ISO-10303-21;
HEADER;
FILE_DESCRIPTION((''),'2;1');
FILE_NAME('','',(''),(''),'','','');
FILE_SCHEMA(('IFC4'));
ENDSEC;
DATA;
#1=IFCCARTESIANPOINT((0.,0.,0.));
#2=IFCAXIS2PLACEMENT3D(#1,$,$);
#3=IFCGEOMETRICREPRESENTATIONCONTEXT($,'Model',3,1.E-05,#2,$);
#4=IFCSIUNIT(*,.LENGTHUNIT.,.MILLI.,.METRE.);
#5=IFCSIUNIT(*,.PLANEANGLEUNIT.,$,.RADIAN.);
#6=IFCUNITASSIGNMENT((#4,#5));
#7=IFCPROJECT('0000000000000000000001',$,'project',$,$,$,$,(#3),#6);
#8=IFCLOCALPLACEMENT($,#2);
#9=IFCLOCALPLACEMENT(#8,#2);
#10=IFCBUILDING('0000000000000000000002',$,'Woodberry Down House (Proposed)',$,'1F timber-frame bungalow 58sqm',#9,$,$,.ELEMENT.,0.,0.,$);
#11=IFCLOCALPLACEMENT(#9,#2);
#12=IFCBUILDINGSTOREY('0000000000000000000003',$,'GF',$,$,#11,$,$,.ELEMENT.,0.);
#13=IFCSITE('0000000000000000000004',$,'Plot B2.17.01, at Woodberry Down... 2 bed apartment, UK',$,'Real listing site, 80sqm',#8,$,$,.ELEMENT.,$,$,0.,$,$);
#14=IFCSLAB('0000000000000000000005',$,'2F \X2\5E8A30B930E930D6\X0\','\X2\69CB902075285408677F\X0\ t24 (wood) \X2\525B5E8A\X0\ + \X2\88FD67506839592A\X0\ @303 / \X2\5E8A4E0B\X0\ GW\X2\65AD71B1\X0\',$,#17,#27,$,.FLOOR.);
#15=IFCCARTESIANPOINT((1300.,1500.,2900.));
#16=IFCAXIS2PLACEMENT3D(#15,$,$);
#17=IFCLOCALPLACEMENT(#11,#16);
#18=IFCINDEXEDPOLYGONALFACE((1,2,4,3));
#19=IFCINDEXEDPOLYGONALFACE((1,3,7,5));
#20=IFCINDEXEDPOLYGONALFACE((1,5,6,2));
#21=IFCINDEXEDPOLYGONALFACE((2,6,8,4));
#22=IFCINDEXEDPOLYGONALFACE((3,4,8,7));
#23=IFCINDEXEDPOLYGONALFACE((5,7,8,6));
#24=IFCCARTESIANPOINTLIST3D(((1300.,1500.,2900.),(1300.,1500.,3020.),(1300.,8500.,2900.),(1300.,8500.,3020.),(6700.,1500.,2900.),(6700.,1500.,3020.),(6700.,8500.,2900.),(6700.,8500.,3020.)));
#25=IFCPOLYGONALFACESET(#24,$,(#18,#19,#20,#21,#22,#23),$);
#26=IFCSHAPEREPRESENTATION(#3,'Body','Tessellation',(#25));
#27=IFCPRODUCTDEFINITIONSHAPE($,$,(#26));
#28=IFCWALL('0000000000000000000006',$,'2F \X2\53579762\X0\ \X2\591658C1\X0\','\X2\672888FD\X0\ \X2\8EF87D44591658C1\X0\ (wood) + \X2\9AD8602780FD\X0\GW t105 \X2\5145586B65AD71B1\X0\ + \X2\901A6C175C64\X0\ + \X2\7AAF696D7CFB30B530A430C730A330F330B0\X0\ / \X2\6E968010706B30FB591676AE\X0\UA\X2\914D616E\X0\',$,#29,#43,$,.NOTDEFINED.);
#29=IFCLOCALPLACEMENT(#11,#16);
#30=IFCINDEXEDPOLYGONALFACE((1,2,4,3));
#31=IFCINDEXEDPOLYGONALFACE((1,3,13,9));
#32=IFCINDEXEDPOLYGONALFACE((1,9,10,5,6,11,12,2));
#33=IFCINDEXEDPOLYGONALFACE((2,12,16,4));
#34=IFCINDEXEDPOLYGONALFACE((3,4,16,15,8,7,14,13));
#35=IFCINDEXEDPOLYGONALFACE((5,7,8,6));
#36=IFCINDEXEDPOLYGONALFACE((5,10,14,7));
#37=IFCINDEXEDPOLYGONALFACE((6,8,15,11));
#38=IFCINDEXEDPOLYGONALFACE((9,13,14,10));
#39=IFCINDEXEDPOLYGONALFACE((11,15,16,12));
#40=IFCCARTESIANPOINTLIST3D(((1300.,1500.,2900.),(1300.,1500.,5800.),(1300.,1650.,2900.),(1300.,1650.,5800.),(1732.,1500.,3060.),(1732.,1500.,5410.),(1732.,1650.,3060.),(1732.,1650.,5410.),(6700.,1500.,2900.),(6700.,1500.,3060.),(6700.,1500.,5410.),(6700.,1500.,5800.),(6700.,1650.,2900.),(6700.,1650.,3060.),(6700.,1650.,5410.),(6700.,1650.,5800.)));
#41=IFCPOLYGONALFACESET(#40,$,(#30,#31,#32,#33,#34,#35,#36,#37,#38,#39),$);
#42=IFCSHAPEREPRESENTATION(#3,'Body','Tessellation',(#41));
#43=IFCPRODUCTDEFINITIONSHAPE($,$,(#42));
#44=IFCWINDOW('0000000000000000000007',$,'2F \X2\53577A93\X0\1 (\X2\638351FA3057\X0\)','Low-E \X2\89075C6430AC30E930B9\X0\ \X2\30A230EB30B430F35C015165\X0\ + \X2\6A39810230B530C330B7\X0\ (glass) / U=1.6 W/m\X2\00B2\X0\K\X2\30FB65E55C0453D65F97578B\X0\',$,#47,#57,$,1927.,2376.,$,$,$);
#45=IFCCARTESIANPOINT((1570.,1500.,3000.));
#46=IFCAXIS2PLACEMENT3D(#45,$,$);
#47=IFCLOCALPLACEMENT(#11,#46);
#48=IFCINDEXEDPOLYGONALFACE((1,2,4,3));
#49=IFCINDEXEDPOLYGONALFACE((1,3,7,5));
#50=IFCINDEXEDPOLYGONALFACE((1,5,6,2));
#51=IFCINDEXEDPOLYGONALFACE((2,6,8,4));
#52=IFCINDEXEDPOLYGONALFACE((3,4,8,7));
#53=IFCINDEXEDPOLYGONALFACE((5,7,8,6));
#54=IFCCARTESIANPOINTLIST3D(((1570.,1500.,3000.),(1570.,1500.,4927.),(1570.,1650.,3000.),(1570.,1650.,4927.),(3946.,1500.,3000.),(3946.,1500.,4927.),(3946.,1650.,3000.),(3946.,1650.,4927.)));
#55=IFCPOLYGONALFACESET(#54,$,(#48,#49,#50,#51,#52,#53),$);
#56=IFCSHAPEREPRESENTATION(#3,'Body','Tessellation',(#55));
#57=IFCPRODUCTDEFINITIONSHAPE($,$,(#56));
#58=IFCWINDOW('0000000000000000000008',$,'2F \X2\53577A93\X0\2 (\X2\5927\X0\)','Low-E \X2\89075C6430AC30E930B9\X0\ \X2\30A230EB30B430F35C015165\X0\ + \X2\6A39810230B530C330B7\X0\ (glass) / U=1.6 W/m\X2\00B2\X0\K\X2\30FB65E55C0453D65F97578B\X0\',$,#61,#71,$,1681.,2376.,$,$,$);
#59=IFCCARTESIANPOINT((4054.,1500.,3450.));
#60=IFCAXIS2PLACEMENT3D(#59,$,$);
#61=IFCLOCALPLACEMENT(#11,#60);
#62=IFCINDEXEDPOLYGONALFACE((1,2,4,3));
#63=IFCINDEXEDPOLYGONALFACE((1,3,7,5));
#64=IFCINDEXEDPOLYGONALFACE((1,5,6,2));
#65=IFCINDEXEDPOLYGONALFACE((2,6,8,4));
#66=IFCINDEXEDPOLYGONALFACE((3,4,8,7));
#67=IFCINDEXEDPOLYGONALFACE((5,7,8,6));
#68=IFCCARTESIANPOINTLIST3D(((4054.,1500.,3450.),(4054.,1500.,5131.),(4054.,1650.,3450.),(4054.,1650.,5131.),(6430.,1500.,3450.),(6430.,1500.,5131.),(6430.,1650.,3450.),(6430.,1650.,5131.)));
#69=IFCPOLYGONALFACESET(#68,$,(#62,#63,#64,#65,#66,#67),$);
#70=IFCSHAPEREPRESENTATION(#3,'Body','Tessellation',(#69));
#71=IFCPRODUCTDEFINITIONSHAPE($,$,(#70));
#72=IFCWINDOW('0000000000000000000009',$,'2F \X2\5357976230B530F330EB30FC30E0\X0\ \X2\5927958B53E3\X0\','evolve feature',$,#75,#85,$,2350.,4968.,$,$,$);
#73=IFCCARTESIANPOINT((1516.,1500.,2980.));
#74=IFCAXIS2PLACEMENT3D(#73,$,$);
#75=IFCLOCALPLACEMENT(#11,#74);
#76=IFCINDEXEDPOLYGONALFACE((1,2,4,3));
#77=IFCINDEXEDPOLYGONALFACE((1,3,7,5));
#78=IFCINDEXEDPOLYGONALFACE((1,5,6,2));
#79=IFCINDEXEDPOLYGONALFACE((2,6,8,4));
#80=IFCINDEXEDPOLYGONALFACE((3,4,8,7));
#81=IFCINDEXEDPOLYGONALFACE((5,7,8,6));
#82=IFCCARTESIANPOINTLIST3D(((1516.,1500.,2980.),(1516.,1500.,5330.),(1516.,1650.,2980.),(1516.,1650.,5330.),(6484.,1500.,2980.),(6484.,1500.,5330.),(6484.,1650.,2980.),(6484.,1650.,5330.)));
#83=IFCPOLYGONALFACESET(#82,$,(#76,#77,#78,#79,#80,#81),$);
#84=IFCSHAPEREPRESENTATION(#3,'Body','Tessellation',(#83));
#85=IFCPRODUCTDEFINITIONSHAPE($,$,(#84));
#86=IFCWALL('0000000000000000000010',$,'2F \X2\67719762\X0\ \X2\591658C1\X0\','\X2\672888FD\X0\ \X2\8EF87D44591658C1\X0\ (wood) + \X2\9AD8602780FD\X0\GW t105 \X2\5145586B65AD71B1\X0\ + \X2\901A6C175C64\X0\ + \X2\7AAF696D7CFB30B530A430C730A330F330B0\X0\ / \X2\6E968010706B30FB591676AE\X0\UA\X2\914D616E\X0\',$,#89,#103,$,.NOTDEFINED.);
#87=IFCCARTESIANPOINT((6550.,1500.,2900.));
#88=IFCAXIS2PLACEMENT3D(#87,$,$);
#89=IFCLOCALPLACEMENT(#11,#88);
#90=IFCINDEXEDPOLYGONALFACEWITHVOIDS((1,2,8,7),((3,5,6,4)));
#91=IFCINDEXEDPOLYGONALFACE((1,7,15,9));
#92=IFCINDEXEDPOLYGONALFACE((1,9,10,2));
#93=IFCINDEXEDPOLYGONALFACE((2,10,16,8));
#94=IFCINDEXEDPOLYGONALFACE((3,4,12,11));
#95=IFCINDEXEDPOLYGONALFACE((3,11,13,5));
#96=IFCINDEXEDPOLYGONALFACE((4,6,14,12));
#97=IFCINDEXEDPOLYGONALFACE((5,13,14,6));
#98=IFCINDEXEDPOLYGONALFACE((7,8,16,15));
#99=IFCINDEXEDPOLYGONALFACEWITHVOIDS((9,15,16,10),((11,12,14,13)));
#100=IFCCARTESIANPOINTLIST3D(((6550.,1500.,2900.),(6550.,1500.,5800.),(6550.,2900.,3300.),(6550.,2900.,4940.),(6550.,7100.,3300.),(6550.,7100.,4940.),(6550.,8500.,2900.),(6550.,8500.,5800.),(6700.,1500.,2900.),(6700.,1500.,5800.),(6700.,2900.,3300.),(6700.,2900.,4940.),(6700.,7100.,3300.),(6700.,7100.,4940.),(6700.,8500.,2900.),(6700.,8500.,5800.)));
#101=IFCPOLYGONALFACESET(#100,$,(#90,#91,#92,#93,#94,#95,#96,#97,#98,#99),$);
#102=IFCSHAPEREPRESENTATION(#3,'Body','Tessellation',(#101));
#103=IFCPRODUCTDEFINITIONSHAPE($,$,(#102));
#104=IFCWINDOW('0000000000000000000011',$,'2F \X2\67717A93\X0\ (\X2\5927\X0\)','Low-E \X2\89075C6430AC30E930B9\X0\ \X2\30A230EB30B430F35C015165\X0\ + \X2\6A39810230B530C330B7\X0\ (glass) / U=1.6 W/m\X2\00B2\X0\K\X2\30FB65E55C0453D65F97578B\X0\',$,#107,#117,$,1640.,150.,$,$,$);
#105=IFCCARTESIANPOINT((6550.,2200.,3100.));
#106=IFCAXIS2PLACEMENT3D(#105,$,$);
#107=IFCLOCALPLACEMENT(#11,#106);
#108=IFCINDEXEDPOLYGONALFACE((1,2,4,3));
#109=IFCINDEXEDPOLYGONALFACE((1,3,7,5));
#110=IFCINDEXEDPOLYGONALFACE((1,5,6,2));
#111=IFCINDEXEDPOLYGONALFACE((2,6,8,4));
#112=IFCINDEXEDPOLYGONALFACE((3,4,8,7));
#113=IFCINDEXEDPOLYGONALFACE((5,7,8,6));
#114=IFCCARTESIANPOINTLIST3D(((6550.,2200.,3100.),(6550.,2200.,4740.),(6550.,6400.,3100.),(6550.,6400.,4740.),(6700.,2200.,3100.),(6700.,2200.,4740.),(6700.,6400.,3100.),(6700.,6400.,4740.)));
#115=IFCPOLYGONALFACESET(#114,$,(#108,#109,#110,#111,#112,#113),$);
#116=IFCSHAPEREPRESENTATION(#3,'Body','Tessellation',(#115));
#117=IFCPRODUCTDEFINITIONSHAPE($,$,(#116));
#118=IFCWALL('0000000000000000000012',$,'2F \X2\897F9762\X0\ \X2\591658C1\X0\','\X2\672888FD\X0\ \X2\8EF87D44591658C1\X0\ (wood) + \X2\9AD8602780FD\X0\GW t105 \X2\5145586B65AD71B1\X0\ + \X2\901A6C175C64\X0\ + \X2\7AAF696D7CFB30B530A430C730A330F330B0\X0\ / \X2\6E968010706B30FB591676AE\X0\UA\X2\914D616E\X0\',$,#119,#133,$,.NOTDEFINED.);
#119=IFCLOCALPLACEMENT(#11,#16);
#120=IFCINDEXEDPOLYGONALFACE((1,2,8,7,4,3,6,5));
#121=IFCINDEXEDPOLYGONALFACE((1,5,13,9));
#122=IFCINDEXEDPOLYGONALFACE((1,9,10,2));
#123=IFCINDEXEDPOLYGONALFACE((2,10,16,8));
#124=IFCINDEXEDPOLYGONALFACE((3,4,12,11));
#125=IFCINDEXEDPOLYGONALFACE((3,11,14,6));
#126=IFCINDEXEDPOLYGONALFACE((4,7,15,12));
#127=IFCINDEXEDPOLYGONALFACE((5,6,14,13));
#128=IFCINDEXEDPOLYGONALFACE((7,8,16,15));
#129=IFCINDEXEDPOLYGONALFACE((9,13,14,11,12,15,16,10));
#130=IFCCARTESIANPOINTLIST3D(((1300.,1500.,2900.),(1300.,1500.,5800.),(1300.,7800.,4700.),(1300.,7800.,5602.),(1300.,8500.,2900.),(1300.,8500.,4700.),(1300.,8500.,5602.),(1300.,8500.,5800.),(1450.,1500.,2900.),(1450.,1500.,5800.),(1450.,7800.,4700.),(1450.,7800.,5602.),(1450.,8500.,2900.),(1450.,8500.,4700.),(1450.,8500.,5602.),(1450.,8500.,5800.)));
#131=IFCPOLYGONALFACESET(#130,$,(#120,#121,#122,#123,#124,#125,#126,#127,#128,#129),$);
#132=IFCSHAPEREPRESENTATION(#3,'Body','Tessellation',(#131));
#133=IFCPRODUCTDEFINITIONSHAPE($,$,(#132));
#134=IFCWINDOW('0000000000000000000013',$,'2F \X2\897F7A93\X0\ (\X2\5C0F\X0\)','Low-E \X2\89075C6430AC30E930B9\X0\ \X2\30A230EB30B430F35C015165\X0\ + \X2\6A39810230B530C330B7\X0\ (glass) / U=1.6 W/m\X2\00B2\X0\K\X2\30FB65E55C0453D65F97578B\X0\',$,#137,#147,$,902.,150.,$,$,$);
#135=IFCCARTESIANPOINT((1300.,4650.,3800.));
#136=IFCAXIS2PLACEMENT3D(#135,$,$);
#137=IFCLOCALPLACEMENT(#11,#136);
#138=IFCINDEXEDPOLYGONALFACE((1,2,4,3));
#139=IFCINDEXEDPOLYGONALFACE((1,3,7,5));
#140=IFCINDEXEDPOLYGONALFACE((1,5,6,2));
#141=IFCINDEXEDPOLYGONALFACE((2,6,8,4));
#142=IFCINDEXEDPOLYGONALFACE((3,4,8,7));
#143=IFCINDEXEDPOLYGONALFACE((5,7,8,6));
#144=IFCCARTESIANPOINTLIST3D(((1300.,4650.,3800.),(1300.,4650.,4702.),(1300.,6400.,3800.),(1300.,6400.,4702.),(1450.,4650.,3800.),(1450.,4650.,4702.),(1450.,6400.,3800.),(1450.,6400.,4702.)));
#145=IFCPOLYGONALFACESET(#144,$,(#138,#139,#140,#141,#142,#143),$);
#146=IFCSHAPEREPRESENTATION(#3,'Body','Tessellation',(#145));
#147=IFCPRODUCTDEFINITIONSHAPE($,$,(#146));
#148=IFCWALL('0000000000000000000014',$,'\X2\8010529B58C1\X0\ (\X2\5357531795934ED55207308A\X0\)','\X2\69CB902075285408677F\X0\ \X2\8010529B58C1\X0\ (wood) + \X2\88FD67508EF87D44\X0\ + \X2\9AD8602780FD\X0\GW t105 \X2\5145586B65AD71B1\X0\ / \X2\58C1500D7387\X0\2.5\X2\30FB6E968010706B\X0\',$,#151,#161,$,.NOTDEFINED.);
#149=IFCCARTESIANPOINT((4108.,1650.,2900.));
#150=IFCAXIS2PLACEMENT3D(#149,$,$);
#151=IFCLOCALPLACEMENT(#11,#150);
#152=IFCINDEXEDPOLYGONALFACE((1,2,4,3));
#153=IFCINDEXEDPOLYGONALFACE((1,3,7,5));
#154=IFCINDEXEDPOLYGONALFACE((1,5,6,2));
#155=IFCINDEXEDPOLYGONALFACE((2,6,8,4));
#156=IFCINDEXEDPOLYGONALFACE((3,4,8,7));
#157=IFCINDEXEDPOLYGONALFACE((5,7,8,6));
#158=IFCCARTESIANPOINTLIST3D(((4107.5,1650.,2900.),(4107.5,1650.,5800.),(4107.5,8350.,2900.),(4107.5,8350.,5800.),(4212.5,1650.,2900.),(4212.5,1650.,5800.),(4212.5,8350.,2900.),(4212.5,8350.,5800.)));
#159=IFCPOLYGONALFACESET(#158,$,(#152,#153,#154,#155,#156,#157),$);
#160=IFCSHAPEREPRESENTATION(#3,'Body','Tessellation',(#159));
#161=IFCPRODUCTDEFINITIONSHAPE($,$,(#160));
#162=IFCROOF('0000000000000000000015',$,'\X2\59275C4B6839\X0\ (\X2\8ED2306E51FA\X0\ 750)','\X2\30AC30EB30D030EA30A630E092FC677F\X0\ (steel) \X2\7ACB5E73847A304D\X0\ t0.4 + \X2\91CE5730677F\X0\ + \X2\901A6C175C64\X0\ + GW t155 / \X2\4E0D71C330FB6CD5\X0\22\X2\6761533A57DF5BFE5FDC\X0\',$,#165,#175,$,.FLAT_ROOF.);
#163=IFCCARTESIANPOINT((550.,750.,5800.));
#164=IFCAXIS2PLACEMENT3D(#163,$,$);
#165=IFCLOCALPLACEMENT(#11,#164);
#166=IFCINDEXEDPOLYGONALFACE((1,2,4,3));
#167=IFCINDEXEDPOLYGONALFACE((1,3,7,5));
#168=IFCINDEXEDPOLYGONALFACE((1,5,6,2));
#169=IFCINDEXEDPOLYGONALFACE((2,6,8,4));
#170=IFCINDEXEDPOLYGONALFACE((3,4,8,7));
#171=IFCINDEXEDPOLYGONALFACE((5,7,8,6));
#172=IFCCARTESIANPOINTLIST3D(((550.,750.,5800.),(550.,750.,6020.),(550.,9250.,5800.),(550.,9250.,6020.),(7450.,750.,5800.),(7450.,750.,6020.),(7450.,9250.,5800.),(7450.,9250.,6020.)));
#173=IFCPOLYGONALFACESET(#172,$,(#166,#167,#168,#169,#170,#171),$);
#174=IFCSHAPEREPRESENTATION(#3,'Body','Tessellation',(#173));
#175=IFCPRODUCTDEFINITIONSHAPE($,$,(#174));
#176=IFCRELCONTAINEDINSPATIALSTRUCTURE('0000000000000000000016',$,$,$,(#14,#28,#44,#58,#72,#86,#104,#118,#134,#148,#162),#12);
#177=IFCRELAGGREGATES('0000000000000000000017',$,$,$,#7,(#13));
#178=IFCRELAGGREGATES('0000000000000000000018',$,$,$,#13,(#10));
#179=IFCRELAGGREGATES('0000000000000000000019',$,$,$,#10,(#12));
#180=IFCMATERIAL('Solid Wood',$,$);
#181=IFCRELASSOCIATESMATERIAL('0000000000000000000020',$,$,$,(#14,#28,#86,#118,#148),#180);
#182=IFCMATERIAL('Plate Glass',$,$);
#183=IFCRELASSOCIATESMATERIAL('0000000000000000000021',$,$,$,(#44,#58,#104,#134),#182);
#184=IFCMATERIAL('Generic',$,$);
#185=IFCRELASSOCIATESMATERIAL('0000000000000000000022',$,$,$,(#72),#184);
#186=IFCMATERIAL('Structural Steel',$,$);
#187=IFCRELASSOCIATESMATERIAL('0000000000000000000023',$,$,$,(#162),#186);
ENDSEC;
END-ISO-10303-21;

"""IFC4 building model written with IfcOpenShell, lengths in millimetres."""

from ifc_helpers import new_model, si_unit, frame, frame_2d, origin, place, context, project, spatial, rectangle, extrude, material, element, fill, save


model = new_model("IFC4")

# Units and contexts
model_context = context("Model", 3, precision=1e-05, world=origin())
ifc_project = project(units=[si_unit("LENGTHUNIT", "METRE", prefix="MILLI"), si_unit("PLANEANGLEUNIT", "RADIAN")], contexts=[model_context])

# Site, building, storey
site_placement = place(None, origin())
site = spatial("IfcSite", under=ifc_project, at=site_placement, Name="Plot B2.17.01, at Woodberry Down... 2 bed apartment, UK", ObjectType="Real listing site, 80sqm", CompositionType="ELEMENT", RefElevation=0.0)
building_placement = place(site_placement, origin())
building = spatial("IfcBuilding", under=site, at=building_placement, Name="Woodberry Down House (Proposed)", ObjectType="1F timber-frame bungalow 58sqm", CompositionType="ELEMENT", ElevationOfRefHeight=0.0, ElevationOfTerrain=0.0)
storey_placement = place(building_placement, origin())
storey = spatial("IfcBuildingStorey", under=building, at=storey_placement, Name="GF", CompositionType="ELEMENT", Elevation=0.0)

# Slab
ifc_material_1 = material(Name="Solid Wood")
slab_placement = place(storey_placement, frame((1300.0, 1500.0, 2900.0)))
element("IfcSlab", 1, at=slab_placement, inside=storey, material=ifc_material_1, Name="2F 床スラブ", Description="構造用合板 t24 (wood) 剛床 + 製材根太 @303 / 床下 GW断熱", PredefinedType="FLOOR", context=model_context, shape_type="SweptSolid", body=[
    extrude(rectangle(XDim=5400.0, YDim=7000.0, at=frame_2d((2700.0, 3500.0))), frame((1300.0, 1500.0, 2900.0)), (0.0, 0.0, 1.0), 120.0),
])

# Wall, openings, windows
wall_1_placement = place(storey_placement, frame((1300.0, 1500.0, 2900.0)))
wall_1 = element("IfcWall", 2, at=wall_1_placement, inside=storey, material=ifc_material_1, Name="2F 南面 外壁", Description="木製 軸組外壁 (wood) + 高性能GW t105 充填断熱 + 通気層 + 窯業系サイディング / 準耐火・外皮UA配慮", PredefinedType="NOTDEFINED", context=model_context, shape_type="SweptSolid", body=[
    extrude(rectangle(XDim=5400.0, YDim=150.0, at=frame_2d((2700.0, 75.0))), frame((1300.0, 1500.0, 2900.0)), (0.0, 0.0, 1.0), 2900.0),
])
opening_1_placement = place(storey_placement, frame((1570.0, 1500.0, 3000.0)))
opening_1 = element("IfcOpeningElement", 3, at=opening_1_placement, cuts=wall_1, PredefinedType="NOTDEFINED", context=model_context, shape_type="SweptSolid", body=[
    extrude(rectangle(XDim=2376.0, YDim=150.0, at=frame_2d((1188.0, 75.0))), frame((1570.0, 1500.0, 3000.0)), (0.0, 0.0, 1.0), 1927.0),
])
opening_2_placement = place(storey_placement, frame((4054.0, 1500.0, 3450.0)))
opening_2 = element("IfcOpeningElement", 4, at=opening_2_placement, cuts=wall_1, PredefinedType="NOTDEFINED", context=model_context, shape_type="SweptSolid", body=[
    extrude(rectangle(XDim=2376.0, YDim=150.0, at=frame_2d((1188.0, 75.0))), frame((4054.0, 1500.0, 3450.0)), (0.0, 0.0, 1.0), 1681.0),
])
opening_3_placement = place(storey_placement, frame((1516.0, 1500.0, 2980.0)))
opening_3 = element("IfcOpeningElement", 5, at=opening_3_placement, cuts=wall_1, PredefinedType="NOTDEFINED", context=model_context, shape_type="SweptSolid", body=[
    extrude(rectangle(XDim=4968.0, YDim=150.0, at=frame_2d((2484.0, 75.0))), frame((1516.0, 1500.0, 2980.0)), (0.0, 0.0, 1.0), 2350.0),
])
ifc_material_2 = material(Name="Plate Glass")
window_1_placement = place(storey_placement, frame((1570.0, 1500.0, 3000.0)))
window_1 = element("IfcWindow", 6, at=window_1_placement, inside=storey, material=ifc_material_2, Name="2F 南窓1 (掃出し)", Description="Low-E 複層ガラス アルゴン封入 + 樹脂サッシ (glass) / U=1.6 W/m²K・日射取得型", OverallHeight=1927.0, OverallWidth=2376.0, context=model_context, shape_type="SweptSolid", body=[
    extrude(rectangle(XDim=2376.0, YDim=150.0, at=frame_2d((1188.0, 75.0))), frame((1570.0, 1500.0, 3000.0)), (0.0, 0.0, 1.0), 1927.0),
])
fill(opening_1, window_1)
window_2_placement = place(storey_placement, frame((4054.0, 1500.0, 3450.0)))
window_2 = element("IfcWindow", 7, at=window_2_placement, inside=storey, material=ifc_material_2, Name="2F 南窓2 (大)", Description="Low-E 複層ガラス アルゴン封入 + 樹脂サッシ (glass) / U=1.6 W/m²K・日射取得型", OverallHeight=1681.0, OverallWidth=2376.0, context=model_context, shape_type="SweptSolid", body=[
    extrude(rectangle(XDim=2376.0, YDim=150.0, at=frame_2d((1188.0, 75.0))), frame((4054.0, 1500.0, 3450.0)), (0.0, 0.0, 1.0), 1681.0),
])
fill(opening_2, window_2)
ifc_material_3 = material(Name="Generic")
window_3_placement = place(storey_placement, frame((1516.0, 1500.0, 2980.0)))
window_3 = element("IfcWindow", 8, at=window_3_placement, inside=storey, material=ifc_material_3, Name="2F 南面サンルーム 大開口", Description="evolve feature", OverallHeight=2350.0, OverallWidth=4968.0, context=model_context, shape_type="SweptSolid", body=[
    extrude(rectangle(XDim=4968.0, YDim=150.0, at=frame_2d((2484.0, 75.0))), frame((1516.0, 1500.0, 2980.0)), (0.0, 0.0, 1.0), 2350.0),
])
fill(opening_3, window_3)

# Walls, openings, windows
wall_2_placement = place(storey_placement, frame((6550.0, 1500.0, 2900.0)))
wall_2 = element("IfcWall", 9, at=wall_2_placement, inside=storey, material=ifc_material_1, Name="2F 東面 外壁", Description="木製 軸組外壁 (wood) + 高性能GW t105 充填断熱 + 通気層 + 窯業系サイディング / 準耐火・外皮UA配慮", PredefinedType="NOTDEFINED", context=model_context, shape_type="SweptSolid", body=[
    extrude(rectangle(XDim=150.0, YDim=7000.0, at=frame_2d((75.0, 3500.0))), frame((6550.0, 1500.0, 2900.0)), (0.0, 0.0, 1.0), 2900.0),
])
opening_4_placement = place(storey_placement, frame((6550.0, 2200.0, 3100.0)))
opening_4 = element("IfcOpeningElement", 10, at=opening_4_placement, cuts=wall_2, PredefinedType="NOTDEFINED", context=model_context, shape_type="SweptSolid", body=[
    extrude(rectangle(XDim=150.0, YDim=4200.0, at=frame_2d((75.0, 2100.0))), frame((6550.0, 2200.0, 3100.0)), (0.0, 0.0, 1.0), 1640.0),
])
window_4_placement = place(storey_placement, frame((6550.0, 2200.0, 3100.0)))
window_4 = element("IfcWindow", 11, at=window_4_placement, inside=storey, material=ifc_material_2, Name="2F 東窓 (大)", Description="Low-E 複層ガラス アルゴン封入 + 樹脂サッシ (glass) / U=1.6 W/m²K・日射取得型", OverallHeight=1640.0, OverallWidth=150.0, context=model_context, shape_type="SweptSolid", body=[
    extrude(rectangle(XDim=150.0, YDim=4200.0, at=frame_2d((75.0, 2100.0))), frame((6550.0, 2200.0, 3100.0)), (0.0, 0.0, 1.0), 1640.0),
])
fill(opening_4, window_4)
wall_3_placement = place(storey_placement, frame((1300.0, 1500.0, 2900.0)))
wall_3 = element("IfcWall", 12, at=wall_3_placement, inside=storey, material=ifc_material_1, Name="2F 西面 外壁", Description="木製 軸組外壁 (wood) + 高性能GW t105 充填断熱 + 通気層 + 窯業系サイディング / 準耐火・外皮UA配慮", PredefinedType="NOTDEFINED", context=model_context, shape_type="SweptSolid", body=[
    extrude(rectangle(XDim=150.0, YDim=7000.0, at=frame_2d((75.0, 3500.0))), frame((1300.0, 1500.0, 2900.0)), (0.0, 0.0, 1.0), 2900.0),
])
opening_5_placement = place(storey_placement, frame((1300.0, 4650.0, 3800.0)))
opening_5 = element("IfcOpeningElement", 13, at=opening_5_placement, cuts=wall_3, PredefinedType="NOTDEFINED", context=model_context, shape_type="SweptSolid", body=[
    extrude(rectangle(XDim=150.0, YDim=1750.0, at=frame_2d((75.0, 875.0))), frame((1300.0, 4650.0, 3800.0)), (0.0, 0.0, 1.0), 902.0),
])
window_5_placement = place(storey_placement, frame((1300.0, 4650.0, 3800.0)))
window_5 = element("IfcWindow", 14, at=window_5_placement, inside=storey, material=ifc_material_2, Name="2F 西窓 (小)", Description="Low-E 複層ガラス アルゴン封入 + 樹脂サッシ (glass) / U=1.6 W/m²K・日射取得型", OverallHeight=902.0, OverallWidth=150.0, context=model_context, shape_type="SweptSolid", body=[
    extrude(rectangle(XDim=150.0, YDim=1750.0, at=frame_2d((75.0, 875.0))), frame((1300.0, 4650.0, 3800.0)), (0.0, 0.0, 1.0), 902.0),
])
fill(opening_5, window_5)

# Wall
wall_4_placement = place(storey_placement, frame((4108.0, 1650.0, 2900.0)))
element("IfcWall", 15, at=wall_4_placement, inside=storey, material=ifc_material_1, Name="耐力壁 (南北間仕切り)", Description="構造用合板 耐力壁 (wood) + 製材軸組 + 高性能GW t105 充填断熱 / 壁倍率2.5・準耐火", PredefinedType="NOTDEFINED", context=model_context, shape_type="SweptSolid", body=[
    extrude(rectangle(XDim=105.0, YDim=6700.0, at=frame_2d((52.0, 3350.0))), frame((4108.0, 1650.0, 2900.0)), (0.0, 0.0, 1.0), 2900.0),
])

# Roof
ifc_material_4 = material(Name="Structural Steel")
roof_placement = place(storey_placement, frame((550.0, 750.0, 5800.0)))
element("IfcRoof", 16, at=roof_placement, inside=storey, material=ifc_material_4, Name="大屋根 (軒の出 750)", Description="ガルバリウム鋼板 (steel) 立平葺き t0.4 + 野地板 + 通気層 + GW t155 / 不燃・法22条区域対応", PredefinedType="FLAT_ROOF", context=model_context, shape_type="SweptSolid", body=[
    extrude(rectangle(XDim=6900.0, YDim=8500.0, at=frame_2d((3450.0, 4250.0))), frame((550.0, 750.0, 5800.0)), (0.0, 0.0, 1.0), 220.0),
])

save(model, "model.ifc")
